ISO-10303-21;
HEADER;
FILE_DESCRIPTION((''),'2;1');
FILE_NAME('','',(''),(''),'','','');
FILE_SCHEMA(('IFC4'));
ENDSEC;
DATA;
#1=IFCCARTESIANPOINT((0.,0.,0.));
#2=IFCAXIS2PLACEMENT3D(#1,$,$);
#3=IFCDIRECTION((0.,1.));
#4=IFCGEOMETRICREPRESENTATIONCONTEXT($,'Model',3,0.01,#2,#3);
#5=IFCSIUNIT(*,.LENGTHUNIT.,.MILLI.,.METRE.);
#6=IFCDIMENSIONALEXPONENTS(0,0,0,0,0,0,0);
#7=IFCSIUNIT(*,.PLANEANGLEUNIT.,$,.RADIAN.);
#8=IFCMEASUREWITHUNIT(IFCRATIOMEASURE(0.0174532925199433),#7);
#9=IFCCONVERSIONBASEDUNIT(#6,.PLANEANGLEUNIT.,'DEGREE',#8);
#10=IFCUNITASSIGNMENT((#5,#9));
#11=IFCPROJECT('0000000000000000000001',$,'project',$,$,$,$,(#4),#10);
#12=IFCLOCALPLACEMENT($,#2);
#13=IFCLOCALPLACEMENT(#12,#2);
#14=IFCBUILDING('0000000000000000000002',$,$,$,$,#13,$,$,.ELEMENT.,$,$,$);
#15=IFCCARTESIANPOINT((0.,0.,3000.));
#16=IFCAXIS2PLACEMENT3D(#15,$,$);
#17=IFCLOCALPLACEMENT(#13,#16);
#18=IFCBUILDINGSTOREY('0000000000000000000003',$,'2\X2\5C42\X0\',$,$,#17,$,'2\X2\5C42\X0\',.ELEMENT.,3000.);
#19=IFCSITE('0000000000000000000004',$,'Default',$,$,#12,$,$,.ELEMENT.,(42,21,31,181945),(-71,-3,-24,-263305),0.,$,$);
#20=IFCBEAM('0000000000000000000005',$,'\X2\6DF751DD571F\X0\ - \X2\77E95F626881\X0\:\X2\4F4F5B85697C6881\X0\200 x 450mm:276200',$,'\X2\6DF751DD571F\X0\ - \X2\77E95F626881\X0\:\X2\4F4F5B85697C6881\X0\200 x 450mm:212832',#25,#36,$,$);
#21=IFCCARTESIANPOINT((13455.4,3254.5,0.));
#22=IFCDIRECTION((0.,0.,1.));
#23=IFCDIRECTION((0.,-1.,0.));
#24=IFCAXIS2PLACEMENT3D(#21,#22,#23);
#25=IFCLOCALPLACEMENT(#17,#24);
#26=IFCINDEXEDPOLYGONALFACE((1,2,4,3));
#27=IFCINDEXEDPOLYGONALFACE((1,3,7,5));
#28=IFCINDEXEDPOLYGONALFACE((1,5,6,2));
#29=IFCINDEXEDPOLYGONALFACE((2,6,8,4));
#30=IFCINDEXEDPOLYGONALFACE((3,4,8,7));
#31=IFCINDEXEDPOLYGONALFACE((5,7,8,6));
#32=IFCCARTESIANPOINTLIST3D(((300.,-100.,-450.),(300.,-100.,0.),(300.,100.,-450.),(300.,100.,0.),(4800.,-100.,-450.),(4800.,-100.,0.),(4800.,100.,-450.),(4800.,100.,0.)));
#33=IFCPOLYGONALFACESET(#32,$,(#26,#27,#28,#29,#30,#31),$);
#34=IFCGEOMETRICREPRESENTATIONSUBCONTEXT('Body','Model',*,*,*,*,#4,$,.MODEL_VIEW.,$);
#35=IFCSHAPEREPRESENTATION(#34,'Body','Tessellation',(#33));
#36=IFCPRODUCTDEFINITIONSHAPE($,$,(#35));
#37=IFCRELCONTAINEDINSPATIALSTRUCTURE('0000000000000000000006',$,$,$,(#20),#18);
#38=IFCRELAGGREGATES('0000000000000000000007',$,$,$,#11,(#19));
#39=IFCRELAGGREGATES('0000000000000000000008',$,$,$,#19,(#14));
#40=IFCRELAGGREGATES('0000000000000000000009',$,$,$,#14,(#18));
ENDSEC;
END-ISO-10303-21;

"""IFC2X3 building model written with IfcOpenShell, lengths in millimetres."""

from ifc_helpers import new_model, entity, si_unit, converted_unit, direction, frame, frame_2d, origin, place, context, subcontext, project, spatial, rectangle, extrude, element, save


model = new_model("IFC2X3")

# Units and contexts
model_context = context("Model", 3, precision=0.01, world=origin(), true_north=direction((0.0, 1.0)))
body_context = subcontext(model_context, "Body", "Model", "MODEL_VIEW")
ifc_project = project(units=[si_unit("LENGTHUNIT", "METRE", prefix="MILLI"), converted_unit("PLANEANGLEUNIT", "DEGREE", entity("IfcRatioMeasure", 0.0174532925199433), si_unit("PLANEANGLEUNIT", "RADIAN"), dimensions=[0, 0, 0, 0, 0, 0, 0])], contexts=[model_context])

# Site, building, storey
site_placement = place(None, origin())
site = spatial("IfcSite", under=ifc_project, at=site_placement, Name="Default", CompositionType="ELEMENT", RefLatitude=(42, 21, 31, 181945), RefLongitude=(-71, -3, -24, -263305), RefElevation=0.0)
building_placement = place(site_placement, origin())
building = spatial("IfcBuilding", under=site, at=building_placement, CompositionType="ELEMENT")
storey_placement = place(building_placement, frame((0.0, 0.0, 3000.0)))
storey = spatial("IfcBuildingStorey", under=building, at=storey_placement, Name="2层", LongName="2层", CompositionType="ELEMENT", Elevation=3000.0)

# Beam
beam_1_placement = place(storey_placement, frame((13455.4, 3254.5, 0.0), z_axis=(0.0, 0.0, 1.0), x_axis=(0.0, -1.0, 0.0)))
element("IfcBeam", 1, at=beam_1_placement, inside=storey, Name="混凝土 - 矩形梁:住宅楼梁200 x 450mm:276200", ObjectType="混凝土 - 矩形梁:住宅楼梁200 x 450mm:212832", context=body_context, shape_type="SweptSolid", body=[
    extrude(rectangle(XDim=450.0, YDim=200.0, at=frame_2d((0.0, 0.0), x_axis=(1.0, 0.0))), frame((300.0, 0.0, -225.0), z_axis=(1.0, 0.0, 0.0), x_axis=(0.0, 0.0, -1.0)), (0.0, 0.0, 1.0), 4500.0),
])

save(model, "model.ifc")
